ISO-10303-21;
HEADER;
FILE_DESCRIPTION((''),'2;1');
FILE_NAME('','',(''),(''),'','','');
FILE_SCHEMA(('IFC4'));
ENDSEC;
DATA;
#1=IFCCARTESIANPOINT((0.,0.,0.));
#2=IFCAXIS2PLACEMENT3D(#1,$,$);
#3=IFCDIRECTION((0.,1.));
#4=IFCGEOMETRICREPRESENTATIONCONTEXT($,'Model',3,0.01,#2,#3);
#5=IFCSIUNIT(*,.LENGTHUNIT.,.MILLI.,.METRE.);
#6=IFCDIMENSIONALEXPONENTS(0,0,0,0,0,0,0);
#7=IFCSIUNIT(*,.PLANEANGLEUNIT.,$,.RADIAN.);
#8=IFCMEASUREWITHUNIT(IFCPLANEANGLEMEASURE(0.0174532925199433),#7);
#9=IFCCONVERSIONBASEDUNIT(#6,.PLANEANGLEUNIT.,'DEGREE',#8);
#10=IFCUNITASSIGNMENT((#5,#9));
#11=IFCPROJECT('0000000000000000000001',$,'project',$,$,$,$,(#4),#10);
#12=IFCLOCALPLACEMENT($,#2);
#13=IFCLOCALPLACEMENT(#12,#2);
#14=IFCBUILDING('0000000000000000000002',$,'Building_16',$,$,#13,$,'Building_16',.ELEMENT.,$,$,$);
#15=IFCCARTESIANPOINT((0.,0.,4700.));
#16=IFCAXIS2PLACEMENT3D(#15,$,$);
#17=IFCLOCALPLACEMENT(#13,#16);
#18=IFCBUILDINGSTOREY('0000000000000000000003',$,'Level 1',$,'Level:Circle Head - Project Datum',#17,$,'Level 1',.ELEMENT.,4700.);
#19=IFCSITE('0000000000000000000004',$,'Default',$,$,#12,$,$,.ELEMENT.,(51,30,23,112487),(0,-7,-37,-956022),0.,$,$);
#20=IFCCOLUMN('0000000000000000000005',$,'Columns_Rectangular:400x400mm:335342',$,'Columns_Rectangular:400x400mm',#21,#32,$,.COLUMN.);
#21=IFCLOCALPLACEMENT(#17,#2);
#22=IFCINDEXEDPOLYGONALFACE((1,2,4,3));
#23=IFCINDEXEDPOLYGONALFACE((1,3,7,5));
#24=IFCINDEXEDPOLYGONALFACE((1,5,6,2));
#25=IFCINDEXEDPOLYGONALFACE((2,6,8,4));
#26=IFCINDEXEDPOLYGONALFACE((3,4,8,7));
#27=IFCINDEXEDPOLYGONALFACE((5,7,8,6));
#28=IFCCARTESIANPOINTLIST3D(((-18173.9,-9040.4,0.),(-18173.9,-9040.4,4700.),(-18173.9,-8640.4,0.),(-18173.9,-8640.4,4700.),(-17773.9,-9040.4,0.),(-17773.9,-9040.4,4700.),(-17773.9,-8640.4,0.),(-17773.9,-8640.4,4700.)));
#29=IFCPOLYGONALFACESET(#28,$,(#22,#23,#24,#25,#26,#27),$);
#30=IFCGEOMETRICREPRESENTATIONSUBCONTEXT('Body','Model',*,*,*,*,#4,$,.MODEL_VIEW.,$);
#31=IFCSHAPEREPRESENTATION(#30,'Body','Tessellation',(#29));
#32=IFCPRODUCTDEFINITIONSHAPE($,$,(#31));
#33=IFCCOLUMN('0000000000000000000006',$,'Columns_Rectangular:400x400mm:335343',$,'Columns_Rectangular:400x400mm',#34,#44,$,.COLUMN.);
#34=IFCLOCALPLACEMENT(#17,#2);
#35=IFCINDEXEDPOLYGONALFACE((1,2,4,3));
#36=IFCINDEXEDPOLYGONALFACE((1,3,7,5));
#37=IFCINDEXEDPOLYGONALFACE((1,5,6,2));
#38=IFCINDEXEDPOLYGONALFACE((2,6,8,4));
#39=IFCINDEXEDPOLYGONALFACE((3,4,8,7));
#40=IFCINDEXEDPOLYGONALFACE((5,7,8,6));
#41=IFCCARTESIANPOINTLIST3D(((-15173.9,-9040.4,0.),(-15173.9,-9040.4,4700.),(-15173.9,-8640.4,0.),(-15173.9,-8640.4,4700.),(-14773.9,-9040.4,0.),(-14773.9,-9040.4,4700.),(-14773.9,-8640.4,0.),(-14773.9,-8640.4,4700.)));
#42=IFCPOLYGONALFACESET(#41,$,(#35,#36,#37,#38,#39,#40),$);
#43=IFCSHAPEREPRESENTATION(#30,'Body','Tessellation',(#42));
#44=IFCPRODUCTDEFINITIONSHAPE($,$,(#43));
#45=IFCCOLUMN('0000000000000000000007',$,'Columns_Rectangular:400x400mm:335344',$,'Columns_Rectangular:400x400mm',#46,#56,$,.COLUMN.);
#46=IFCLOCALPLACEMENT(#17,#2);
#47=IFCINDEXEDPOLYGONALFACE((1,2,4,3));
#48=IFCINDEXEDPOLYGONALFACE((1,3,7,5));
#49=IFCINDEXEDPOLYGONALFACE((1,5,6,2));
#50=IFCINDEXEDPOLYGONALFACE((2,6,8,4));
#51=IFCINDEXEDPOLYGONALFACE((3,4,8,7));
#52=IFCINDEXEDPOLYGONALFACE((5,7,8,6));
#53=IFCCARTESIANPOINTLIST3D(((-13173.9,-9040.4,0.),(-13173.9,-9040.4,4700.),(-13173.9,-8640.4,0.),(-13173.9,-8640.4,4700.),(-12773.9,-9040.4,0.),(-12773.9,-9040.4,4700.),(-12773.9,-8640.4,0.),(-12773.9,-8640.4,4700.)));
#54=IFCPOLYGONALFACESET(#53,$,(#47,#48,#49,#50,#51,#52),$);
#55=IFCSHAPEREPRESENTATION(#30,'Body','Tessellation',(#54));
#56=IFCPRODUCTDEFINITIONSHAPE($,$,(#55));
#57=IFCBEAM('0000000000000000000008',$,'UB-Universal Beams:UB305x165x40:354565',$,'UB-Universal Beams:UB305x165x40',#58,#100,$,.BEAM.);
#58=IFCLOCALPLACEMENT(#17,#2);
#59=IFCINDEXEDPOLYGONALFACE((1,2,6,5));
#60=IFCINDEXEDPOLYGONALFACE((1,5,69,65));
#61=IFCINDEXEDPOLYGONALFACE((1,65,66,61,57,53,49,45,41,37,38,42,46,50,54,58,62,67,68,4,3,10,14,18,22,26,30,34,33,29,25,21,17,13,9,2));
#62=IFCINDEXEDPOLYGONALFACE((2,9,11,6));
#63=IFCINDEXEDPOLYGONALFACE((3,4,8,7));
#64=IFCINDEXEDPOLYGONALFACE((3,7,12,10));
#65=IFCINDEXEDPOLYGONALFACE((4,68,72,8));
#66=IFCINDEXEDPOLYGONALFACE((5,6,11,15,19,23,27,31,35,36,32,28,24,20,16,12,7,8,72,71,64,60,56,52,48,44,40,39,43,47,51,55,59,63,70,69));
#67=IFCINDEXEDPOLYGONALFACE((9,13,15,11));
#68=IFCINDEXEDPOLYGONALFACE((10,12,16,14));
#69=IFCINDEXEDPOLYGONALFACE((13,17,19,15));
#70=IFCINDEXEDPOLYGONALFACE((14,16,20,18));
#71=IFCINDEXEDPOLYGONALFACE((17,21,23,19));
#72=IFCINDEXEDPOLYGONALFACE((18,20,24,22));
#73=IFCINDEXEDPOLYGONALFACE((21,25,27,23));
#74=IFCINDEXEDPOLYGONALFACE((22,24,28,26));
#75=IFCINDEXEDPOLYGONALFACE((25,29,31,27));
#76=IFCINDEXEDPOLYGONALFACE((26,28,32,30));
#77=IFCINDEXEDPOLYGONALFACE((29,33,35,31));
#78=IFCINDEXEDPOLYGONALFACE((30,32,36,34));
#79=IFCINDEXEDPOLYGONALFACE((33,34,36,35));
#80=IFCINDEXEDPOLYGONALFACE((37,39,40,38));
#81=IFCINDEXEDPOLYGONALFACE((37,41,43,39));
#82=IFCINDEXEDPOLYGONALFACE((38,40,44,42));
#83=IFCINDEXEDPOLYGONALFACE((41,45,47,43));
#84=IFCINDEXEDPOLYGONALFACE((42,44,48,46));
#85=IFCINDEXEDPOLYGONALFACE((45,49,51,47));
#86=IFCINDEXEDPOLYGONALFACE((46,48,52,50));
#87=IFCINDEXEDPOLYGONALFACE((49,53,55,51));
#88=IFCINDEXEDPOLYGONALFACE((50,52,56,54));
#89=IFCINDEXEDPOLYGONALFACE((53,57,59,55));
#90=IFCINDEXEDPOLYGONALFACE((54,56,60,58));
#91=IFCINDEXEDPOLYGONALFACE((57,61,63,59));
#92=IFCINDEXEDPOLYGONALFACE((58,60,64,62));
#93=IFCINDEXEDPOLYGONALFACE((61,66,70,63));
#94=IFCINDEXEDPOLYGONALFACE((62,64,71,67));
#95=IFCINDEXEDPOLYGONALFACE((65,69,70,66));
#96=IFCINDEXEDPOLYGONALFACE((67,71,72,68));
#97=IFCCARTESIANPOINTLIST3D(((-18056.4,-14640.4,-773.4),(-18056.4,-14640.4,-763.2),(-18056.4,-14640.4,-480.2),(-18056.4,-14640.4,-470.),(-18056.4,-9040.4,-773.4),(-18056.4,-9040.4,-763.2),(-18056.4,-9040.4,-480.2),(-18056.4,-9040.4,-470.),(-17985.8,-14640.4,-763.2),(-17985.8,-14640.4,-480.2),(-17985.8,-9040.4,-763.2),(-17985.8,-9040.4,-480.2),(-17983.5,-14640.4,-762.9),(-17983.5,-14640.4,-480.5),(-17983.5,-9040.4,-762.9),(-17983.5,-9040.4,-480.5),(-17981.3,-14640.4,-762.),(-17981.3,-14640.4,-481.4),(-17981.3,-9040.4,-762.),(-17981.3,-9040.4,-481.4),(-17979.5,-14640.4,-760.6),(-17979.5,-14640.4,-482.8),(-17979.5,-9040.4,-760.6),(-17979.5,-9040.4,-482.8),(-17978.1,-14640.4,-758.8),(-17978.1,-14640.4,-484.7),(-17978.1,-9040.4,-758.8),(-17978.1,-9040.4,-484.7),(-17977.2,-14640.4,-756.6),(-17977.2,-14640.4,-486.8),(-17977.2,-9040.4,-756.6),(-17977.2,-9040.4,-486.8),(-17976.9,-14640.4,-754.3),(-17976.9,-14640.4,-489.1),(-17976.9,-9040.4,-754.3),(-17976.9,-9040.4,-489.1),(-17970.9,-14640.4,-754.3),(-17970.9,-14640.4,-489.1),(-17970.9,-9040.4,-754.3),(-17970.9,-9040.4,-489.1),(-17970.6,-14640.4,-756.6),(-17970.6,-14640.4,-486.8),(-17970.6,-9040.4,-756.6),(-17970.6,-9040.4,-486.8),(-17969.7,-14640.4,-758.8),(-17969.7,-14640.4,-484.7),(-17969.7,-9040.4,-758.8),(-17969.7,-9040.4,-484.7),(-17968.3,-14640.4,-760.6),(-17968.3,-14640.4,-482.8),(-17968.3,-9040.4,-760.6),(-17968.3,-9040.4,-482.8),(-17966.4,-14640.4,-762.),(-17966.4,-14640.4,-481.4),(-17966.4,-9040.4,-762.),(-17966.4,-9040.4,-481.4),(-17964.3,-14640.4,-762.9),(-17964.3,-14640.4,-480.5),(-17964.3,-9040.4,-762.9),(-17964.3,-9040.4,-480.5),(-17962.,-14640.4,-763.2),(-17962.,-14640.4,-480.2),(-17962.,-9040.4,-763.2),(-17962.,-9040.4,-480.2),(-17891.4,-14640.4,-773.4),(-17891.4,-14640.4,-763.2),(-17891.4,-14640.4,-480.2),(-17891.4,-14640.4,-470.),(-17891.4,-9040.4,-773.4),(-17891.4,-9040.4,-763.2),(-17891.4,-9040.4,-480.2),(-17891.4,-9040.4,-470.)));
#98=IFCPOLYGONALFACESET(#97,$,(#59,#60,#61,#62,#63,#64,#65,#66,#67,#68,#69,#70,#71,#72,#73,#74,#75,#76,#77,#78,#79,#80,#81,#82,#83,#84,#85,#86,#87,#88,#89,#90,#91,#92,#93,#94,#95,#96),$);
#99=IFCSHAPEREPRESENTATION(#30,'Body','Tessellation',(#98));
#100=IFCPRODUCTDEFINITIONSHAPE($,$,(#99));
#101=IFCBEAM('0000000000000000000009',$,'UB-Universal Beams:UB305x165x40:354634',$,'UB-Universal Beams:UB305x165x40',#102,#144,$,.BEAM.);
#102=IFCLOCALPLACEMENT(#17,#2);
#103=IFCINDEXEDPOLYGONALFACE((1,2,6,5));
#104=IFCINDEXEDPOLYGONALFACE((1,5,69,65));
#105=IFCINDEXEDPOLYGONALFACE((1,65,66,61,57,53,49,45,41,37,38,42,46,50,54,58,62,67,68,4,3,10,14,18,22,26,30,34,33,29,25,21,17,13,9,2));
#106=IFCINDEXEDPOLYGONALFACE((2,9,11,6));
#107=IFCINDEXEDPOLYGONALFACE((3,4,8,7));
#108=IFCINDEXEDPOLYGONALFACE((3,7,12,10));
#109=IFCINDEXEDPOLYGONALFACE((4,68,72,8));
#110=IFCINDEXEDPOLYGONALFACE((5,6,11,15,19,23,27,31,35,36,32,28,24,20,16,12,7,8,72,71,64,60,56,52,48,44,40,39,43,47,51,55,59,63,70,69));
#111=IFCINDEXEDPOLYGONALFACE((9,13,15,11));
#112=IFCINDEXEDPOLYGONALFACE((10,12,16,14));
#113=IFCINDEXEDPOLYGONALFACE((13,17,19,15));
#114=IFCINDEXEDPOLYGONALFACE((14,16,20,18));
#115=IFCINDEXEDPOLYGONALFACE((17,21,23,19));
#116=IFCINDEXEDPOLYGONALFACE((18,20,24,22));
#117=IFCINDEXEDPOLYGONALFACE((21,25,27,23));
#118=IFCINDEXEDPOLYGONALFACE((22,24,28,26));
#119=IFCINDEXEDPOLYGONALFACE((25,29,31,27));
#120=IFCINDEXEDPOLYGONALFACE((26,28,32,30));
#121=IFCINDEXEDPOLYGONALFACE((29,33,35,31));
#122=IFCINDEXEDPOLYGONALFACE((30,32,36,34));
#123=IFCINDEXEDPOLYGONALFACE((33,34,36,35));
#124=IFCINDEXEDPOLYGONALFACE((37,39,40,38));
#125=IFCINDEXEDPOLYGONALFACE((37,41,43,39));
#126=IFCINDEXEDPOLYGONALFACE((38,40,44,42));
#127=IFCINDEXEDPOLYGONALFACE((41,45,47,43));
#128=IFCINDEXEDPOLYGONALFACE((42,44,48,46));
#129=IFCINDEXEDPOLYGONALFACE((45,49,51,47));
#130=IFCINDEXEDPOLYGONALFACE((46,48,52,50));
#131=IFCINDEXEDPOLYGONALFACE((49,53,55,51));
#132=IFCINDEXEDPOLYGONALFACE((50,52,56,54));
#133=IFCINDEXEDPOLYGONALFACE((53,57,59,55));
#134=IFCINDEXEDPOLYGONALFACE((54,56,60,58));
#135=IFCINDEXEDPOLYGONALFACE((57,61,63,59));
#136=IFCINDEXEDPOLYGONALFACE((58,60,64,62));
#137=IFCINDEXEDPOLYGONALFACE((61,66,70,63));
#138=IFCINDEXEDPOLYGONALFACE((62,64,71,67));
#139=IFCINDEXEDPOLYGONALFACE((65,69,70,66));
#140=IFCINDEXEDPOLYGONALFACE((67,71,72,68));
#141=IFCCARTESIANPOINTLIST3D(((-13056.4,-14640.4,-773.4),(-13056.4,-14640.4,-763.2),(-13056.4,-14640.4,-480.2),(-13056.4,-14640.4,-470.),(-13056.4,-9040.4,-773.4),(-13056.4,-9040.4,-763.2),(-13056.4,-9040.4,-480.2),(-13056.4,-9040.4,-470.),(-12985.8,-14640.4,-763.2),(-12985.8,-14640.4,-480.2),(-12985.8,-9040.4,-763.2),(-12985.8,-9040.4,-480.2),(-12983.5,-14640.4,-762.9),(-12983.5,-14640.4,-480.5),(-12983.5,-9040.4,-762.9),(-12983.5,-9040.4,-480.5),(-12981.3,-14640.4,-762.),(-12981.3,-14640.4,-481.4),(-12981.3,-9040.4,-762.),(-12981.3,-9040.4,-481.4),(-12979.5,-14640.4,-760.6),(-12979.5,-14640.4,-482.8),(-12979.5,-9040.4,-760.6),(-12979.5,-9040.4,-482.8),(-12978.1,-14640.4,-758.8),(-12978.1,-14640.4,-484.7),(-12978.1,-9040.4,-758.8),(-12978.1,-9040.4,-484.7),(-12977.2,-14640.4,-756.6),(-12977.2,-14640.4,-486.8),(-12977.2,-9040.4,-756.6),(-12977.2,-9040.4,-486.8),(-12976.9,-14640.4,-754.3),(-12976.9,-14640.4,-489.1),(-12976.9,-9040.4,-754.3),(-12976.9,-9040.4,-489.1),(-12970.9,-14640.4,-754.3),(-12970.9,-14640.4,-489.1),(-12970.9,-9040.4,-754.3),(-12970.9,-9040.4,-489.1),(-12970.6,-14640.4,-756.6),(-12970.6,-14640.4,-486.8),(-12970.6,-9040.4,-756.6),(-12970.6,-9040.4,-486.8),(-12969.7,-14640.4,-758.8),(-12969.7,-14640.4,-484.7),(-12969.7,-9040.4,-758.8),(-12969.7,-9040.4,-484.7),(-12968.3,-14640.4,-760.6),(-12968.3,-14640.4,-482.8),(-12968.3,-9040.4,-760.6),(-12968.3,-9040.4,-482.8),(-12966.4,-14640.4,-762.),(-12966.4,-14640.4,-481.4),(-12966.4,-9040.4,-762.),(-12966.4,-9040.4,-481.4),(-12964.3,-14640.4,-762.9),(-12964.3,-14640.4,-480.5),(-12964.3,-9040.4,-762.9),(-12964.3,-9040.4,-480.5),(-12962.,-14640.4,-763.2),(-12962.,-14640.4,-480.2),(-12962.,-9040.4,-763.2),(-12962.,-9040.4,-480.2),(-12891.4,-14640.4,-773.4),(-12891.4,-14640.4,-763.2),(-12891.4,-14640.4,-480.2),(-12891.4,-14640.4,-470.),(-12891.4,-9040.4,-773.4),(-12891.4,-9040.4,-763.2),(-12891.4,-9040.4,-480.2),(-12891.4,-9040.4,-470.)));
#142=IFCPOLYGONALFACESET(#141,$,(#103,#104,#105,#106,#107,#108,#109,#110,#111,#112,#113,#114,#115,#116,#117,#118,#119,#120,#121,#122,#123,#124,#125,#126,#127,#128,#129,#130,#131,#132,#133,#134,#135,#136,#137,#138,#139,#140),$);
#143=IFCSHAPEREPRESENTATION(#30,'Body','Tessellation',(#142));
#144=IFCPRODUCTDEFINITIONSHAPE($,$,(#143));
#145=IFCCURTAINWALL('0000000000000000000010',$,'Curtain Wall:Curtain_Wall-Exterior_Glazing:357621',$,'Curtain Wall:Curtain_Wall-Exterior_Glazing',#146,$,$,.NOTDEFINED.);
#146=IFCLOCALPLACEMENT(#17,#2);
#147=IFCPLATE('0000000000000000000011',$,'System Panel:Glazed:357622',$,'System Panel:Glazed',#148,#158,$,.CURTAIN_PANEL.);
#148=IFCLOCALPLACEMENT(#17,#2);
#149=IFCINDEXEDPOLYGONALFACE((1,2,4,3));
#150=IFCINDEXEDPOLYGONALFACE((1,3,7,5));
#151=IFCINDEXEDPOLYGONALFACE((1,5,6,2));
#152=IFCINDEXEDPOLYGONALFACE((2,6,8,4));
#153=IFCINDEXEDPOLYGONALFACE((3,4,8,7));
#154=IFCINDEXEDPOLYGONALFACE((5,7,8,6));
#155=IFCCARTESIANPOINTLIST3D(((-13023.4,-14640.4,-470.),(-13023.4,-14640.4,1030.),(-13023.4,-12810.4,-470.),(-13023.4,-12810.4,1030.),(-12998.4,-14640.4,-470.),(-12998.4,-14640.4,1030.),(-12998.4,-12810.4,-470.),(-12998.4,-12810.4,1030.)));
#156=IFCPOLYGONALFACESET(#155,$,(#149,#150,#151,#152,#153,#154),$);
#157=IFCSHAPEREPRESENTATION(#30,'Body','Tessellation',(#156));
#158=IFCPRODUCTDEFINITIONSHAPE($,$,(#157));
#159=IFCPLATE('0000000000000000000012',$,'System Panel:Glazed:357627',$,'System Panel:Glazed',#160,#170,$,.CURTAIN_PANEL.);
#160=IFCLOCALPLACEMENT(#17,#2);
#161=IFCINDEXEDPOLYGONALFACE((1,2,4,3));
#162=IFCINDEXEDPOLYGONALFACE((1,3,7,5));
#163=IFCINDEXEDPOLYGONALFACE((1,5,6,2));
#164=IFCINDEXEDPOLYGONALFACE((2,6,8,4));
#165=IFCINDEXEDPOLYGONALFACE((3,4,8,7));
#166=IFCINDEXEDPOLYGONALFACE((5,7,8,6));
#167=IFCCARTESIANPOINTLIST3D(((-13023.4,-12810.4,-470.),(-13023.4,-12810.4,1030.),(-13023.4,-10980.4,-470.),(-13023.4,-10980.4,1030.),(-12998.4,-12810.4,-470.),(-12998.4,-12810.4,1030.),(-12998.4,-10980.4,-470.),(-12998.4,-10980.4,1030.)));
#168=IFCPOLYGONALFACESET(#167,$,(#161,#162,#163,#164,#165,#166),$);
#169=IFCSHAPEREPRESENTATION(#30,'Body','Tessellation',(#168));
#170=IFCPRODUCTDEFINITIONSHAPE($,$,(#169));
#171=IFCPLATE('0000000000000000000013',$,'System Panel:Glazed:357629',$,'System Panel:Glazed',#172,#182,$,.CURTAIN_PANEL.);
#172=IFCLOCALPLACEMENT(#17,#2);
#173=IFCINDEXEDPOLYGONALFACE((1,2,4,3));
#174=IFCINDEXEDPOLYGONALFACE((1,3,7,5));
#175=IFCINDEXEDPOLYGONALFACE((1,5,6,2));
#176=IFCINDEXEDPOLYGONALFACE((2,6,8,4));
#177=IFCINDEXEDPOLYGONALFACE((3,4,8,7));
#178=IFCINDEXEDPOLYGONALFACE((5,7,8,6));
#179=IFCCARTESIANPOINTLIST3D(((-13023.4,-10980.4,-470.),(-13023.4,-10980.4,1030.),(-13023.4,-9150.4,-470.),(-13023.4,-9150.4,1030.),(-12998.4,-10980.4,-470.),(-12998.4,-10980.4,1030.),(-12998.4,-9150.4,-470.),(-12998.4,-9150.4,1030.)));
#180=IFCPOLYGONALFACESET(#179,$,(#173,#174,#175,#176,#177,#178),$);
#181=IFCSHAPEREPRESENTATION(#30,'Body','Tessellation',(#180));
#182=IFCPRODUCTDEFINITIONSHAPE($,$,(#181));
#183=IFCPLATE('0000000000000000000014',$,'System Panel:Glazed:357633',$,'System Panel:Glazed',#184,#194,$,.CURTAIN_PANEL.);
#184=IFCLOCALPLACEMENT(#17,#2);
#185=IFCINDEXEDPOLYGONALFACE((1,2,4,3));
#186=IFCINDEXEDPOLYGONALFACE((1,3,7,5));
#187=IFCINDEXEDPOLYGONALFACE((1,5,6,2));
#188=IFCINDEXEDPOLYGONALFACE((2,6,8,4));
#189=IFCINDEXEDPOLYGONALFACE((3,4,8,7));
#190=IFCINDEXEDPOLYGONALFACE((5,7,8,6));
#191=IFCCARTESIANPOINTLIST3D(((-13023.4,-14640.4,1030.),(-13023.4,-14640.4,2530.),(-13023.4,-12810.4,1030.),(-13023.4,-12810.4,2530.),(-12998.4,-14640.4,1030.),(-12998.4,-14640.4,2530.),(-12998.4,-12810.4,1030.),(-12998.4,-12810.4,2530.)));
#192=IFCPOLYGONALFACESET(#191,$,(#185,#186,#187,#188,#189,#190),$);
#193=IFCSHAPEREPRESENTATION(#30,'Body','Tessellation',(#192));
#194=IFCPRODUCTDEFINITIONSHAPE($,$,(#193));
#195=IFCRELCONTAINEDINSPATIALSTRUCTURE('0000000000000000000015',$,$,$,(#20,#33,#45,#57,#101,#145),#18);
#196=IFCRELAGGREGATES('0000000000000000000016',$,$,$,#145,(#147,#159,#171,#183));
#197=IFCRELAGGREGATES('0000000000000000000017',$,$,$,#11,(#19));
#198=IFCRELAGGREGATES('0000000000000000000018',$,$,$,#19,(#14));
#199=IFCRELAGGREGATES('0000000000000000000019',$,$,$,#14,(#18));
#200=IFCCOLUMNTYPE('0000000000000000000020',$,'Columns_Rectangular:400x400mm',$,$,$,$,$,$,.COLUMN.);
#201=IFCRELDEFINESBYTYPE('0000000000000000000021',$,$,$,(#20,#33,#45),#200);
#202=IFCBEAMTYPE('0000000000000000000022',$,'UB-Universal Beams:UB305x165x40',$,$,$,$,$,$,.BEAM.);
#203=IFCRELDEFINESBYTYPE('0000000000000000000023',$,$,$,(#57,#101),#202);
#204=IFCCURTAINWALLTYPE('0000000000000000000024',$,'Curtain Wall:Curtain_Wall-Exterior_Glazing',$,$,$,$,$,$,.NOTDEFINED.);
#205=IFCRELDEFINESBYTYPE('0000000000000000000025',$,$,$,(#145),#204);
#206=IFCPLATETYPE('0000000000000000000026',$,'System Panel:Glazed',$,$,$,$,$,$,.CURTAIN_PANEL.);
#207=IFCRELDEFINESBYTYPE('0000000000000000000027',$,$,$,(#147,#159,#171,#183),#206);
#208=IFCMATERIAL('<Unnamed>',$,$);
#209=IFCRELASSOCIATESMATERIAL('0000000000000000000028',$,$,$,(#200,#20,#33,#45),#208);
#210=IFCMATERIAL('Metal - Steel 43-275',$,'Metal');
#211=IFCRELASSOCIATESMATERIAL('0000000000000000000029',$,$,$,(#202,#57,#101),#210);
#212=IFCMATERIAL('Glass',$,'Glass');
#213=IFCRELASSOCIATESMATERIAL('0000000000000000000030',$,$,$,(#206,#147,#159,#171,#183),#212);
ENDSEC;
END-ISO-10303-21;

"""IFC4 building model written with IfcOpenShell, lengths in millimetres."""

from ifc_helpers import new_model, entity, si_unit, converted_unit, direction, frame, origin, place, context, subcontext, project, spatial, line, arc, indexed_curve, outline, extrude, source, transform, mapped, material, type_object, type_shapes, element, aggregate, save


model = new_model("IFC4")

# Units and contexts
model_context = context("Model", 3, precision=0.01, world=origin(), true_north=direction((0.0, 1.0)))
body_context = subcontext(model_context, "Body", "Model", "MODEL_VIEW")
ifc_project = project(units=[si_unit("LENGTHUNIT", "METRE", prefix="MILLI"), converted_unit("PLANEANGLEUNIT", "DEGREE", entity("IfcPlaneAngleMeasure", 0.0174532925199433), si_unit("PLANEANGLEUNIT", "RADIAN"), dimensions=[0, 0, 0, 0, 0, 0, 0])], contexts=[model_context])

# Site, building, storey
site_placement = place(None, origin())
site = spatial("IfcSite", under=ifc_project, at=site_placement, Name="Default", CompositionType="ELEMENT", RefLatitude=(51, 30, 23, 112487), RefLongitude=(0, -7, -37, -956022), RefElevation=0.0)
building_placement = place(site_placement, origin())
building = spatial("IfcBuilding", under=site, at=building_placement, Name="Building_16", LongName="Building_16", CompositionType="ELEMENT")
storey_placement = place(building_placement, frame((0.0, 0.0, 4700.0)))
storey = spatial("IfcBuildingStorey", under=building, at=storey_placement, Name="Level 1", ObjectType="Level:Circle Head - Project Datum", LongName="Level 1", CompositionType="ELEMENT", Elevation=4700.0)

# Columns
ifc_material_1 = material(Name="<Unnamed>")
column_type = type_object("IfcColumnType", Name="Columns_Rectangular:400x400mm", PredefinedType="COLUMN", material=ifc_material_1)
shared_shape_1 = source(origin(), body_context, "Body", "SweptSolid", [
    extrude(outline(indexed_curve([(-200.0, -200.0), (200.0, -200.0), (200.0, 200.0), (-200.0, 200.0), (-200.0, -200.0)], self_intersect=False)), frame((0.0, 0.0, 4700.0), z_axis=(0.0, 0.0, 1.0), x_axis=(-1.0, 0.0, 0.0)), (0.0, 0.0, 1.0), 4700.0),
])
type_shapes(column_type, [shared_shape_1])
for number, where, name in (
    (1, (-17973.9, -8840.4, -4700.0), "Columns_Rectangular:400x400mm:335342"),
    (2, (-14973.9, -8840.4, -4700.0), "Columns_Rectangular:400x400mm:335343"),
    (3, (-12973.9, -8840.4, -4700.0), "Columns_Rectangular:400x400mm:335344"),
):
    element("IfcColumn", number, at=place(storey_placement, frame(where)), inside=storey, type_object=column_type, material=ifc_material_1, Name=name, ObjectType="Columns_Rectangular:400x400mm", PredefinedType="COLUMN", context=body_context, shape_type="MappedRepresentation", body=[
        mapped(shared_shape_1, transform((0.0, 0.0, 0.0), scale=1.0)),
    ])

# Beams
ifc_material_2 = material(Name="Metal - Steel 43-275", Category="Metal")
beam_type = type_object("IfcBeamType", Name="UB-Universal Beams:UB305x165x40", PredefinedType="BEAM", material=ifc_material_2)
shared_shape_2 = source(origin(), body_context, "Body", "SweptSolid", [
    extrude(outline(indexed_curve([(-82.5, -141.5), (-82.5, -151.7), (82.5, -151.7), (82.5, -141.5), (11.9, -141.5), (5.6, -138.9), (3.0, -132.6), (3.0, 132.6), (5.6, 138.9), (11.9, 141.5), (82.5, 141.5), (82.5, 151.7), (-82.5, 151.7), (-82.5, 141.5), (-11.9, 141.5), (-5.6, 138.9), (-3.0, 132.6), (-3.0, -132.6), (-5.6, -138.9), (-11.9, -141.5)], segments=[line(1, 2, 3, 4, 5), arc(5, 6, 7), line(7, 8), arc(8, 9, 10), line(10, 11, 12, 13, 14, 15), arc(15, 16, 17), line(17, 18), arc(18, 19, 20), line(20, 1)], self_intersect=False)), frame((-2800.0, 0.0, 0.0), z_axis=(-1.0, 0.0, 0.0), x_axis=(0.0, -1.0, 0.0)), (0.0, 0.0, -1.0), 5600.0),
])
type_shapes(beam_type, [shared_shape_2])
for number, where, z_axis, x_axis, name in (
    (4, (-17973.9, -11840.4, -621.7), (0.0, 0.0, 1.0), (0.0, 1.0, 0.0), "UB-Universal Beams:UB305x165x40:354565"),
    (5, (-12973.9, -11840.4, -621.7), (0.0, 0.0, 1.0), (0.0, 1.0, 0.0), "UB-Universal Beams:UB305x165x40:354634"),
):
    element("IfcBeam", number, at=place(storey_placement, frame(where, z_axis=z_axis, x_axis=x_axis)), inside=storey, type_object=beam_type, material=ifc_material_2, Name=name, ObjectType="UB-Universal Beams:UB305x165x40", PredefinedType="BEAM", context=body_context, shape_type="MappedRepresentation", body=[
        mapped(shared_shape_2, transform((0.0, 0.0, 0.0), scale=1.0)),
    ])

# Curtain wall, plates
curtain_wall_type = type_object("IfcCurtainWallType", Name="Curtain Wall:Curtain_Wall-Exterior_Glazing", PredefinedType="NOTDEFINED")
curtain_wall_1_placement = place(storey_placement, frame((0.0, 0.0, -4700.0)))
curtain_wall_1 = element("IfcCurtainWall", 6, at=curtain_wall_1_placement, inside=storey, type_object=curtain_wall_type, Name="Curtain Wall:Curtain_Wall-Exterior_Glazing:357621", ObjectType="Curtain Wall:Curtain_Wall-Exterior_Glazing", PredefinedType="NOTDEFINED")
ifc_material_3 = material(Name="Glass", Category="Glass")
plate_type_1 = type_object("IfcPlateType", Name="System Panel:Glazed", PredefinedType="CURTAIN_PANEL", material=ifc_material_3)
shared_shape_3 = source(origin(), body_context, "Body", "SweptSolid", [
    extrude(outline(indexed_curve([(-12.5, -915.0), (12.5, -915.0), (12.5, 915.0), (-12.5, 915.0), (-12.5, -915.0)], self_intersect=False)), frame((0.0, 37.0, 0.0), z_axis=(0.0, 0.0, 1.0), x_axis=(0.0, 1.0, 0.0)), (0.0, 0.0, 1.0), 1500.0),
])
type_shapes(plate_type_1, [shared_shape_3])
plate_1_placement = place(curtain_wall_1_placement, frame((-12973.9, -13725.4, 4230.0), z_axis=(0.0, 0.0, 1.0), x_axis=(0.0, 1.0, 0.0)))
plate_1 = element("IfcPlate", 7, at=plate_1_placement, type_object=plate_type_1, material=ifc_material_3, Name="System Panel:Glazed:357622", ObjectType="System Panel:Glazed", PredefinedType="CURTAIN_PANEL", context=body_context, shape_type="MappedRepresentation", body=[
    mapped(shared_shape_3, transform((0.0, 0.0, 0.0), scale=1.0)),
])
plate_2_placement = place(curtain_wall_1_placement, frame((-12973.9, -11895.4, 4230.0), z_axis=(0.0, 0.0, 1.0), x_axis=(0.0, 1.0, 0.0)))
plate_2 = element("IfcPlate", 8, at=plate_2_placement, type_object=plate_type_1, material=ifc_material_3, Name="System Panel:Glazed:357627", ObjectType="System Panel:Glazed", PredefinedType="CURTAIN_PANEL", context=body_context, shape_type="MappedRepresentation", body=[
    mapped(shared_shape_3, transform((0.0, 0.0, 0.0), scale=1.0)),
])
plate_3_placement = place(curtain_wall_1_placement, frame((-12973.9, -10065.4, 4230.0), z_axis=(0.0, 0.0, 1.0), x_axis=(0.0, 1.0, 0.0)))
plate_3 = element("IfcPlate", 9, at=plate_3_placement, type_object=plate_type_1, material=ifc_material_3, Name="System Panel:Glazed:357629", ObjectType="System Panel:Glazed", PredefinedType="CURTAIN_PANEL", context=body_context, shape_type="MappedRepresentation", body=[
    mapped(shared_shape_3, transform((0.0, 0.0, 0.0), scale=1.0)),
])
plate_4_placement = place(curtain_wall_1_placement, frame((-12973.9, -13725.4, 5730.0), z_axis=(0.0, 0.0, 1.0), x_axis=(0.0, 1.0, 0.0)))
plate_4 = element("IfcPlate", 10, at=plate_4_placement, type_object=plate_type_1, material=ifc_material_3, Name="System Panel:Glazed:357633", ObjectType="System Panel:Glazed", PredefinedType="CURTAIN_PANEL", context=body_context, shape_type="MappedRepresentation", body=[
    mapped(shared_shape_3, transform((0.0, 0.0, 0.0), scale=1.0)),
])

aggregate(curtain_wall_1, [plate_1, plate_2, plate_3, plate_4])

save(model, "model.ifc")
